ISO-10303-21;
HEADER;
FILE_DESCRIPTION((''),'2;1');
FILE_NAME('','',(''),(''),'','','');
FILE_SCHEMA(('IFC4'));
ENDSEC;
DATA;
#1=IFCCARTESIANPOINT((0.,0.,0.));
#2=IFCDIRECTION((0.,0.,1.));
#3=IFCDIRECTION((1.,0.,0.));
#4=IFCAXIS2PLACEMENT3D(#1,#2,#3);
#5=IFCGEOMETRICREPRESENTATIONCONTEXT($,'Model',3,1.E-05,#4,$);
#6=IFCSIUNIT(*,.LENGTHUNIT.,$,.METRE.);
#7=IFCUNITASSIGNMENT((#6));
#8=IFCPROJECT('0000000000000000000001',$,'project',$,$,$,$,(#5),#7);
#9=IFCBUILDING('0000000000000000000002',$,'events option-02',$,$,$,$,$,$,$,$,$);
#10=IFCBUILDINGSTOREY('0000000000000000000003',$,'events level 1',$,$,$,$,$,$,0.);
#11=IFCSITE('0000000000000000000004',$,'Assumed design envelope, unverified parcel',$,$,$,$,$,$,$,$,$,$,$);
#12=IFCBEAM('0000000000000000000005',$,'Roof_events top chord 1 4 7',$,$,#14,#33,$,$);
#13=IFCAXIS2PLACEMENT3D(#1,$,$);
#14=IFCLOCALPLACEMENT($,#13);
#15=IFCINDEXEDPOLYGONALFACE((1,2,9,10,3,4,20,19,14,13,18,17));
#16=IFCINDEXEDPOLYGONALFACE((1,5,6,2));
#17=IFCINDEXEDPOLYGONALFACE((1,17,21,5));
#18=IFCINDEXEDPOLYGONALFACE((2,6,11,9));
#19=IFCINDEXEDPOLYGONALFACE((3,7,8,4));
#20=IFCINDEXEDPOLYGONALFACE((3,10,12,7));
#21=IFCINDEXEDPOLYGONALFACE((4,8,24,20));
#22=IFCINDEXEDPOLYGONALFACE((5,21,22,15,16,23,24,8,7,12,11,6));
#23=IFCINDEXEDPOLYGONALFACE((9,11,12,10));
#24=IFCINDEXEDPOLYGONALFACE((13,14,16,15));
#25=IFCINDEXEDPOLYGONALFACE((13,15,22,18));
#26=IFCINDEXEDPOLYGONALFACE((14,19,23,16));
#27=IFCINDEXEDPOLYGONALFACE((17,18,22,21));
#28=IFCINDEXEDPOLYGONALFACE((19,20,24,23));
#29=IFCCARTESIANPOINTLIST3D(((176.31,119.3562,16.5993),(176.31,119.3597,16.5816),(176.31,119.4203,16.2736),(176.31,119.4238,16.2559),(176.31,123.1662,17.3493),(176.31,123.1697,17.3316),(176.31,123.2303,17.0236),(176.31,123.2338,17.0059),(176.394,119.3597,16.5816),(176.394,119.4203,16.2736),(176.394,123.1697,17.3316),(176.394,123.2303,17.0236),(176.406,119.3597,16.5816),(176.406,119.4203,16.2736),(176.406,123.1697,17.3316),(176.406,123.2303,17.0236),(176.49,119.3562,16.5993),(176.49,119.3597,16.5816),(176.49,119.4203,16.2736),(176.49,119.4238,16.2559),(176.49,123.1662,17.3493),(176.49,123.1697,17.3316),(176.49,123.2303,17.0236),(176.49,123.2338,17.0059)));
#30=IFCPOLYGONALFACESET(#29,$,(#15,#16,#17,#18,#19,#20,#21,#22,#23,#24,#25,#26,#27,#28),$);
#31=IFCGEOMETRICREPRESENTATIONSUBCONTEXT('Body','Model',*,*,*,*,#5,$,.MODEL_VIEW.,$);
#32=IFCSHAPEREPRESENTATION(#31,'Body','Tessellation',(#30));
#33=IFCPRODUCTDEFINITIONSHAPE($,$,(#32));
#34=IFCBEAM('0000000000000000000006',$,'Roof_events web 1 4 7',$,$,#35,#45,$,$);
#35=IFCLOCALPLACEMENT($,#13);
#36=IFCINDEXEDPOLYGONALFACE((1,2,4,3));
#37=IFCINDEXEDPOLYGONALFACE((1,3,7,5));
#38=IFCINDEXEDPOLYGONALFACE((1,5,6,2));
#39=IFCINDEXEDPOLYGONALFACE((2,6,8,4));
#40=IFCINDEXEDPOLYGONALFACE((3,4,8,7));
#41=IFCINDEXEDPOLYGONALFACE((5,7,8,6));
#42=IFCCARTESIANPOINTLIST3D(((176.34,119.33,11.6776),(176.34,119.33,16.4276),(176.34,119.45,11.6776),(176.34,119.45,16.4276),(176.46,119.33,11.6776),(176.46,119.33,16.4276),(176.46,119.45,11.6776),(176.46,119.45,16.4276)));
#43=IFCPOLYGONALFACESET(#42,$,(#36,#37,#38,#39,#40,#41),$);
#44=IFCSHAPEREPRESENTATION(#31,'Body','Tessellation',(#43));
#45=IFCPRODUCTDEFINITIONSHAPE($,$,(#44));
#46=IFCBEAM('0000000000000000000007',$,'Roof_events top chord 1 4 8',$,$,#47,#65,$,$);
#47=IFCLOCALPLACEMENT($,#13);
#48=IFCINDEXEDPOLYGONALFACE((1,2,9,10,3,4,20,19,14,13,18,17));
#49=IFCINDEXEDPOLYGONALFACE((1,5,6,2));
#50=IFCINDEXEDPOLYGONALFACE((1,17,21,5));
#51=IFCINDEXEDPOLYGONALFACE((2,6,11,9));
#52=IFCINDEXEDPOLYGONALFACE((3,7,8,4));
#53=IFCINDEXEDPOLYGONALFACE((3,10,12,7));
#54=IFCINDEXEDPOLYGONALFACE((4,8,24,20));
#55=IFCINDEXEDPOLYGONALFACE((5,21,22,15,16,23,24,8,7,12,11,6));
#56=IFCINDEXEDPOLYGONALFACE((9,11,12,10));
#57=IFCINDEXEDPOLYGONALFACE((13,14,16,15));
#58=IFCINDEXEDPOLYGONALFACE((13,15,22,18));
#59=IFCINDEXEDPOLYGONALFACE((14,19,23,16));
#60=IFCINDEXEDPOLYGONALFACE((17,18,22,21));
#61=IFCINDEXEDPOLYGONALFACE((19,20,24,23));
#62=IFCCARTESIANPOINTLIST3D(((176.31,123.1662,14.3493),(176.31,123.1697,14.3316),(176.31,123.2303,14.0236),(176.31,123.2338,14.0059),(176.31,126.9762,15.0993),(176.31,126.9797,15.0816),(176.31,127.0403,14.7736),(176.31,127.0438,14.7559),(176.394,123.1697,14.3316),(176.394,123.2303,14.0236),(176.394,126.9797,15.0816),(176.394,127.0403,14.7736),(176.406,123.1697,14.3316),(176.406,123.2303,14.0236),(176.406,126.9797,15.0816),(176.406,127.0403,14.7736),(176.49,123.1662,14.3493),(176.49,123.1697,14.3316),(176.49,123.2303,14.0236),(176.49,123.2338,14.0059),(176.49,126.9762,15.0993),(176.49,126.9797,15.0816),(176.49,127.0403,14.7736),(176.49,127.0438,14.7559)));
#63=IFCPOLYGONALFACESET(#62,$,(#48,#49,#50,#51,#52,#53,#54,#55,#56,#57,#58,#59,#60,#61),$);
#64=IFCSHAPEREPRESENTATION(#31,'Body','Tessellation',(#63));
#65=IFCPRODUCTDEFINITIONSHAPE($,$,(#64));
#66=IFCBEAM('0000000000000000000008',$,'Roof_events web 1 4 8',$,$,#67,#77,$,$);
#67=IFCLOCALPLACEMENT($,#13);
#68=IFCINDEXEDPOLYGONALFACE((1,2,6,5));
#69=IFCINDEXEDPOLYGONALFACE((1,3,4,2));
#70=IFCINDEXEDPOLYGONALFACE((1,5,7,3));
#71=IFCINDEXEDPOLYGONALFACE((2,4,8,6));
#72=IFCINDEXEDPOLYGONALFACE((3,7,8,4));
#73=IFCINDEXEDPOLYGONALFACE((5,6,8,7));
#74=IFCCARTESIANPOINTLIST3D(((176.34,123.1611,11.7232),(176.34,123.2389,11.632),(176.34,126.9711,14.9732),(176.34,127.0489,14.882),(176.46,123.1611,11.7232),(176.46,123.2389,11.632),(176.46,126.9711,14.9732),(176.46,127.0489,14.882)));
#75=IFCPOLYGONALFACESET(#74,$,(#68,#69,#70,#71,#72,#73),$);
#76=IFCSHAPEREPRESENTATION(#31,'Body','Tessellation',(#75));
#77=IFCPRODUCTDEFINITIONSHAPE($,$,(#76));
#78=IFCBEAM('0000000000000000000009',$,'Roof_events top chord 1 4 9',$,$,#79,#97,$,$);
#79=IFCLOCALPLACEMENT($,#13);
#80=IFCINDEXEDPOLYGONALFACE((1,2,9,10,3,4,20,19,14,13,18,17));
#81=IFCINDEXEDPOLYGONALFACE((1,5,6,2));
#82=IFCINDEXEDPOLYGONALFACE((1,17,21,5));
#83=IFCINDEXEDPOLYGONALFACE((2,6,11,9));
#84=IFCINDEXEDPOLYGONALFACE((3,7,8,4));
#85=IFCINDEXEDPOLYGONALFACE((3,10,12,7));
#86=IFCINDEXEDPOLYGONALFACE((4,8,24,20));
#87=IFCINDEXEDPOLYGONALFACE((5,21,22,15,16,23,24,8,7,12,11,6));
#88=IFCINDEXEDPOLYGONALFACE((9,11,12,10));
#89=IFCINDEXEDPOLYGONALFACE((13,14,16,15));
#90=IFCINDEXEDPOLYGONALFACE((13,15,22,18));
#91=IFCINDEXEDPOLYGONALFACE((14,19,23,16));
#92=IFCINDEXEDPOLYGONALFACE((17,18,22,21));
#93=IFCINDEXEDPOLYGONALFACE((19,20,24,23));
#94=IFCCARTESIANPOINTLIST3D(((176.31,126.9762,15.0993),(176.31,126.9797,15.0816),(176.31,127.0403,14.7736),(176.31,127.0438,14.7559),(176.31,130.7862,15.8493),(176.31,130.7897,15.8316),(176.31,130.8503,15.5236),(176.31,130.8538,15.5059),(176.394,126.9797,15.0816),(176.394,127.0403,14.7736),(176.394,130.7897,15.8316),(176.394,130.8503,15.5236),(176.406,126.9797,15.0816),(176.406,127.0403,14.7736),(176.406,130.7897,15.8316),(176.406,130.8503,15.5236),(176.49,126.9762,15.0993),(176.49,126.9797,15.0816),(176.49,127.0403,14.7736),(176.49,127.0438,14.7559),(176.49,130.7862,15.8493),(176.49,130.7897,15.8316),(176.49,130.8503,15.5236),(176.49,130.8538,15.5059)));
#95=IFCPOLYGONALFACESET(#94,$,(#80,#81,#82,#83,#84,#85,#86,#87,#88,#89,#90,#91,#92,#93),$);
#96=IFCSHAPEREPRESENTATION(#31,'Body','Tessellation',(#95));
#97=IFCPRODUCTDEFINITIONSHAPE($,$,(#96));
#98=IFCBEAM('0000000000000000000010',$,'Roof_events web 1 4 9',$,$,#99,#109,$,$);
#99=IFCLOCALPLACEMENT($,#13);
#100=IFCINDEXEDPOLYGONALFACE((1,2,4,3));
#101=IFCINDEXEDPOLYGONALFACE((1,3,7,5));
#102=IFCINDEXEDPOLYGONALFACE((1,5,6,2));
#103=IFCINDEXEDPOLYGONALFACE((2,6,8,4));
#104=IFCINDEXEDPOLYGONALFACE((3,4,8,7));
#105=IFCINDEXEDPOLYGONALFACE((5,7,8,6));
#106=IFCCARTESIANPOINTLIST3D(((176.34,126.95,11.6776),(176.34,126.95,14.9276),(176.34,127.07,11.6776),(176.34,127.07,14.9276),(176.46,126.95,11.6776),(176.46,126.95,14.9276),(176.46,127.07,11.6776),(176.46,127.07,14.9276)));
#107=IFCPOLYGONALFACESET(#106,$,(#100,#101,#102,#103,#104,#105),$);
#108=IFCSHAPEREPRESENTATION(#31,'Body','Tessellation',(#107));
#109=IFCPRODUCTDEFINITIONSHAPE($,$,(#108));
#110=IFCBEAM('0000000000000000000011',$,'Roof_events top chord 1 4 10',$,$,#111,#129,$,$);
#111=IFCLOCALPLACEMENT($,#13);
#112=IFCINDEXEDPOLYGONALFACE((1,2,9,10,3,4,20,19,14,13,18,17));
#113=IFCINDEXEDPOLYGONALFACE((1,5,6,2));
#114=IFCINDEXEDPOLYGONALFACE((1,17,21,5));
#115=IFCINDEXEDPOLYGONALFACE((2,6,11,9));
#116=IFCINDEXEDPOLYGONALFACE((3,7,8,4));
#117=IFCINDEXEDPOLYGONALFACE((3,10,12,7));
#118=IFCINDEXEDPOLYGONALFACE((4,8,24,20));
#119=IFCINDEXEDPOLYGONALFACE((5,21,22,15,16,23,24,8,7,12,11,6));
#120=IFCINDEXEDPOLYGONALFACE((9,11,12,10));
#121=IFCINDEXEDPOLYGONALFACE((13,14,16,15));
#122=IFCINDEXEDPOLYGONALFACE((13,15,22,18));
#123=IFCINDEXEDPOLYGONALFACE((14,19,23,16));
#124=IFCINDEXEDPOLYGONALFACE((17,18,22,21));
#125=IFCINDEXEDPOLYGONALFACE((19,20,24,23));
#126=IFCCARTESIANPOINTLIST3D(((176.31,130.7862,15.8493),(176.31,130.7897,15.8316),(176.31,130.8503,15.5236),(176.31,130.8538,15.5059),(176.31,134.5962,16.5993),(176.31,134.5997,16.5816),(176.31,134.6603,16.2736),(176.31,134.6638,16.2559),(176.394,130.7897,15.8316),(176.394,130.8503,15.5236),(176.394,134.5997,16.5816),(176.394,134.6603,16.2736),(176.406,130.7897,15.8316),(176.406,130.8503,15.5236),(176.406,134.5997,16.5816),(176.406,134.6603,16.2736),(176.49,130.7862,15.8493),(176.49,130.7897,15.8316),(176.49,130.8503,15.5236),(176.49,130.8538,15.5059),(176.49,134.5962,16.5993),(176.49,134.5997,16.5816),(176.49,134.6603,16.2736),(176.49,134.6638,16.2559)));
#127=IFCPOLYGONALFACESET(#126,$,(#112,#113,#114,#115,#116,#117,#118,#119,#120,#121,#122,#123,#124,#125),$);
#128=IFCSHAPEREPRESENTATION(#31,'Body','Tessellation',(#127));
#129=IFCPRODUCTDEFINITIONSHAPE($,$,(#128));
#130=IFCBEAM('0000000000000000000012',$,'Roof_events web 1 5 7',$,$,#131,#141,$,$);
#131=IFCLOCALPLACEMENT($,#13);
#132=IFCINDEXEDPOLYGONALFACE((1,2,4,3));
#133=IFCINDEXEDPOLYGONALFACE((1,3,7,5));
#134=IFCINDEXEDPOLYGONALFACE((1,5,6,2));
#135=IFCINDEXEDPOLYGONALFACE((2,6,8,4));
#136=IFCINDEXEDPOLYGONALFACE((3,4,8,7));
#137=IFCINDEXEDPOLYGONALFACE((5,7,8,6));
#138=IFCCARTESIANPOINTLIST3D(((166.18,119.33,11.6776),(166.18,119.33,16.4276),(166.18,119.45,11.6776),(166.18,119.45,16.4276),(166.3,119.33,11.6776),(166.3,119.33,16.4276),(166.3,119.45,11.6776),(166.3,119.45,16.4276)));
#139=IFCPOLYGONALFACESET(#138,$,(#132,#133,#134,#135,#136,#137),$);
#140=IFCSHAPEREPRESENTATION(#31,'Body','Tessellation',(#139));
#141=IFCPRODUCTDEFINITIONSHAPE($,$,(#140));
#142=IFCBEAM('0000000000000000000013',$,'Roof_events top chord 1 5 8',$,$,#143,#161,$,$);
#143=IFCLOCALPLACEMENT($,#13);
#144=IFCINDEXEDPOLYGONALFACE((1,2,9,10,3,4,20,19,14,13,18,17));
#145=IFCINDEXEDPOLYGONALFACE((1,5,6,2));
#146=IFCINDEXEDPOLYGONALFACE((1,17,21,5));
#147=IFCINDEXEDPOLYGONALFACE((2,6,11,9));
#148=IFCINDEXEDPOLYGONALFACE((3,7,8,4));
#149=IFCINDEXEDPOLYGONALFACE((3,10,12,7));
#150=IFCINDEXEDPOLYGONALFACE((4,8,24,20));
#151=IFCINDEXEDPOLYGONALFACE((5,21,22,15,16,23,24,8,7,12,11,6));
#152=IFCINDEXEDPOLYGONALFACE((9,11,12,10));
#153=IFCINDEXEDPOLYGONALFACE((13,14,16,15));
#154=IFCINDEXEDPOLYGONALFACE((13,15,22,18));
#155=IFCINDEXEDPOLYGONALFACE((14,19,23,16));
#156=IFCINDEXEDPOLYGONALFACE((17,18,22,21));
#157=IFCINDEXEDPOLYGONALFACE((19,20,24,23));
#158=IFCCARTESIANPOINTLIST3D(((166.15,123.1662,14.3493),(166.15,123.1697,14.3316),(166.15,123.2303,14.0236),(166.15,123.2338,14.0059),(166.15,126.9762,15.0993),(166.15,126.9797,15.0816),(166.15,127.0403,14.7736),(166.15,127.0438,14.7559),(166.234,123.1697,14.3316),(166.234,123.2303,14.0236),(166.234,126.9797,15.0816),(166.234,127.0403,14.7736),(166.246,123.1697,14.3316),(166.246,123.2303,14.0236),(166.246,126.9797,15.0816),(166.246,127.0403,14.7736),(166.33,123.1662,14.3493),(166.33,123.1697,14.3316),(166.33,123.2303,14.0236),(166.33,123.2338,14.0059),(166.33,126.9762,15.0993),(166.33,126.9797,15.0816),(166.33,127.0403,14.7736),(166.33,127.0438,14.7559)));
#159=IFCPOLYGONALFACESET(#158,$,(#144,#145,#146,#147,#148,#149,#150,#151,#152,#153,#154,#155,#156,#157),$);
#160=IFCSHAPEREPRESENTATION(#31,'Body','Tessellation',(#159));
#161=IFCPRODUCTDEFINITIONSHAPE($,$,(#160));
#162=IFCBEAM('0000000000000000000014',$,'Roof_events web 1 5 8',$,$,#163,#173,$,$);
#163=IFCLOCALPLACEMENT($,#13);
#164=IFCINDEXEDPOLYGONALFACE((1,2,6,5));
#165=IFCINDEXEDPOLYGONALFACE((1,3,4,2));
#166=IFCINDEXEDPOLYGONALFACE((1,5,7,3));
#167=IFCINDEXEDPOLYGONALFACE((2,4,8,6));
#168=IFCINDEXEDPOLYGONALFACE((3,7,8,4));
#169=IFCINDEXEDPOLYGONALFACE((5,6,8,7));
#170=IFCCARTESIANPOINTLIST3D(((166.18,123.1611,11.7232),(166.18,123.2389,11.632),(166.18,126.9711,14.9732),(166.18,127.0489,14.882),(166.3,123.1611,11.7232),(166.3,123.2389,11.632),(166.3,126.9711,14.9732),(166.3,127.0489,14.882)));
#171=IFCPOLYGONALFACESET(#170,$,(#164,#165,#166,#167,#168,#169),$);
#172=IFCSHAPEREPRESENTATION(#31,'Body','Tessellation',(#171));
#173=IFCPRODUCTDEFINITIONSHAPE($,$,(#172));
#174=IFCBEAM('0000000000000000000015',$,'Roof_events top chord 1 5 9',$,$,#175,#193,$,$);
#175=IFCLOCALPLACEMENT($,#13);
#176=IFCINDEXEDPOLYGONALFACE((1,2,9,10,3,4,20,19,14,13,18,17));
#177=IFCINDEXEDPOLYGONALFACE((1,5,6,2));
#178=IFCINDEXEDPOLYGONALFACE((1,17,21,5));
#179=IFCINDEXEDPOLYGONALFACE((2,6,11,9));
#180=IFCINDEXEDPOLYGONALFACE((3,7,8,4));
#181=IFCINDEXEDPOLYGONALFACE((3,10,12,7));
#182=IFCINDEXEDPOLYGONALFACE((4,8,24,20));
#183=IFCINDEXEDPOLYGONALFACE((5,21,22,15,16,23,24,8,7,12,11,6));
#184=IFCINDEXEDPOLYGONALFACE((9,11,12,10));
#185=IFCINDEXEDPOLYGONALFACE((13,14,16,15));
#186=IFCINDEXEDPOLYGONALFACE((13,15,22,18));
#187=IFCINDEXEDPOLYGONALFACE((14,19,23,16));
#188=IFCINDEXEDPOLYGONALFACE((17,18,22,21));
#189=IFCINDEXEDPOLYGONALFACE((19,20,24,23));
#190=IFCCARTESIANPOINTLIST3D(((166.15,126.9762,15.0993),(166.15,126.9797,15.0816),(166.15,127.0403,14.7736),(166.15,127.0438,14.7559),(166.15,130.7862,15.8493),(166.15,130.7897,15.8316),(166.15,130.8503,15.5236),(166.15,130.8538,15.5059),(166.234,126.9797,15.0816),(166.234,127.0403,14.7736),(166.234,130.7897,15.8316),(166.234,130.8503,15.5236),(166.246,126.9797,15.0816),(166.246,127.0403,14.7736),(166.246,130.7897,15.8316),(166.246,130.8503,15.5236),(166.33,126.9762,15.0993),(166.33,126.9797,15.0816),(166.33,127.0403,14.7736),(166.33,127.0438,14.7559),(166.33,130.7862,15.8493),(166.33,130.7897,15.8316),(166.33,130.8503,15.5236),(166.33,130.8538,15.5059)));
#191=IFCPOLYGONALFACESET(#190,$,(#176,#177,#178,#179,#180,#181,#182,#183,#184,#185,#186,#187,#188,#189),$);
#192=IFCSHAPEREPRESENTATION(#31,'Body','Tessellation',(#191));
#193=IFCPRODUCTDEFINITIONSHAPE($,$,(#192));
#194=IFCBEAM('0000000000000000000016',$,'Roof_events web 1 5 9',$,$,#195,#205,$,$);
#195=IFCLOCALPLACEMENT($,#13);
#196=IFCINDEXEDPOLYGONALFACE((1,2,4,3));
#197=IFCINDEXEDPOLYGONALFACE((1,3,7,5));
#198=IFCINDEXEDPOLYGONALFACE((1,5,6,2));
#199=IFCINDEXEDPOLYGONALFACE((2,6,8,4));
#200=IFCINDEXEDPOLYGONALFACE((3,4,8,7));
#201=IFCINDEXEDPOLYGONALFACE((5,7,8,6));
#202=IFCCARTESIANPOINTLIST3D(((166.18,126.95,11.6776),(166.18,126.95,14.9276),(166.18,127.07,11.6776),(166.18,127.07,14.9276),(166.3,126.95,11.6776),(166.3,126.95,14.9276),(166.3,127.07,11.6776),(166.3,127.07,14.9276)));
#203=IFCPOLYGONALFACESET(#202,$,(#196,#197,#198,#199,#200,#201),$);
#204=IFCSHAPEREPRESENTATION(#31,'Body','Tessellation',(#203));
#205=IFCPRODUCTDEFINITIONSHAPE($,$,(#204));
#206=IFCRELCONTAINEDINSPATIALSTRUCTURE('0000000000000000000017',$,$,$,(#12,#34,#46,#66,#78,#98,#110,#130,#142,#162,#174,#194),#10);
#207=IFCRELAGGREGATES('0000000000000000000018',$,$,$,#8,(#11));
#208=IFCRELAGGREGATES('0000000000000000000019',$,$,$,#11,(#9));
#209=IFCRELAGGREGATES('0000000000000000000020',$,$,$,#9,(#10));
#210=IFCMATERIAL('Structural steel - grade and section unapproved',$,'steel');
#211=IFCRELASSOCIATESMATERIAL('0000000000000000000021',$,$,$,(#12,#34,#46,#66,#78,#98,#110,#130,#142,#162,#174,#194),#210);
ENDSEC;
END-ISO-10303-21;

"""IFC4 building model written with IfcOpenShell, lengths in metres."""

from ifc_helpers import new_model, si_unit, frame, origin_with_axes, place, context, subcontext, project, spatial, rectangle, i_section, extrude, material, element, save


model = new_model("IFC4")

# Units and contexts
model_context = context("Model", 3, precision=1e-05, world=origin_with_axes())
body_context = subcontext(model_context, "Body", "Model", "MODEL_VIEW")
ifc_project = project(units=[si_unit("LENGTHUNIT", "METRE")], contexts=[model_context])

# Site, building, storey
site = spatial("IfcSite", under=ifc_project, Name="Assumed design envelope, unverified parcel")
building = spatial("IfcBuilding", under=site, Name="events option-02")
storey = spatial("IfcBuildingStorey", under=building, Name="events level 1", Elevation=0.0)

# Beams
ifc_material_1 = material(Name="Structural steel - grade and section unapproved", Category="steel")
beam_1_placement = place(None, frame((176.4, 119.39, 16.4276), z_axis=(0.0, 0.98117, 0.193144), x_axis=(-1.0, 0.0, 0.0)))
element("IfcBeam", 1, at=beam_1_placement, inside=storey, material=ifc_material_1, Name="Roof_events top chord 1 4 7", context=body_context, shape_type="SweptSolid", body=[
    extrude(i_section(OverallWidth=0.18, OverallDepth=0.35, WebThickness=0.012, FlangeThickness=0.018, FilletRadius=0.0), origin_with_axes(), (0.0, 0.0, 1.0), 3.8831),
])
beam_2_placement = place(None, frame((176.4, 119.39, 11.6776), z_axis=(0.0, 0.0, 1.0), x_axis=(-1.0, 0.0, 0.0)))
element("IfcBeam", 2, at=beam_2_placement, inside=storey, material=ifc_material_1, Name="Roof_events web 1 4 7", context=body_context, shape_type="SweptSolid", body=[
    extrude(rectangle(XDim=0.12, YDim=0.12), origin_with_axes(), (0.0, 0.0, 1.0), 4.75),
])
beam_3_placement = place(None, frame((176.4, 123.2, 14.1776), z_axis=(0.0, 0.98117, 0.193144), x_axis=(-1.0, 0.0, 0.0)))
element("IfcBeam", 3, at=beam_3_placement, inside=storey, material=ifc_material_1, Name="Roof_events top chord 1 4 8", context=body_context, shape_type="SweptSolid", body=[
    extrude(i_section(OverallWidth=0.18, OverallDepth=0.35, WebThickness=0.012, FlangeThickness=0.018, FilletRadius=0.0), origin_with_axes(), (0.0, 0.0, 1.0), 3.8831),
])
beam_4_placement = place(None, frame((176.4, 123.2, 11.6776), z_axis=(0.0, 0.760805, 0.64898), x_axis=(-1.0, 0.0, 0.0)))
element("IfcBeam", 4, at=beam_4_placement, inside=storey, material=ifc_material_1, Name="Roof_events web 1 4 8", context=body_context, shape_type="SweptSolid", body=[
    extrude(rectangle(XDim=0.12, YDim=0.12), origin_with_axes(), (0.0, 0.0, 1.0), 5.0079),
])
beam_5_placement = place(None, frame((176.4, 127.01, 14.9276), z_axis=(0.0, 0.98117, 0.193144), x_axis=(-1.0, 0.0, 0.0)))
element("IfcBeam", 5, at=beam_5_placement, inside=storey, material=ifc_material_1, Name="Roof_events top chord 1 4 9", context=body_context, shape_type="SweptSolid", body=[
    extrude(i_section(OverallWidth=0.18, OverallDepth=0.35, WebThickness=0.012, FlangeThickness=0.018, FilletRadius=0.0), origin_with_axes(), (0.0, 0.0, 1.0), 3.8831),
])
beam_6_placement = place(None, frame((176.4, 127.01, 11.6776), z_axis=(0.0, 0.0, 1.0), x_axis=(-1.0, 0.0, 0.0)))
element("IfcBeam", 6, at=beam_6_placement, inside=storey, material=ifc_material_1, Name="Roof_events web 1 4 9", context=body_context, shape_type="SweptSolid", body=[
    extrude(rectangle(XDim=0.12, YDim=0.12), origin_with_axes(), (0.0, 0.0, 1.0), 3.25),
])
beam_7_placement = place(None, frame((176.4, 130.82, 15.6776), z_axis=(0.0, 0.98117, 0.193144), x_axis=(-1.0, 0.0, 0.0)))
element("IfcBeam", 7, at=beam_7_placement, inside=storey, material=ifc_material_1, Name="Roof_events top chord 1 4 10", context=body_context, shape_type="SweptSolid", body=[
    extrude(i_section(OverallWidth=0.18, OverallDepth=0.35, WebThickness=0.012, FlangeThickness=0.018, FilletRadius=0.0), origin_with_axes(), (0.0, 0.0, 1.0), 3.8831),
])
beam_8_placement = place(None, frame((166.24, 119.39, 11.6776), z_axis=(0.0, 0.0, 1.0), x_axis=(-1.0, 0.0, 0.0)))
element("IfcBeam", 8, at=beam_8_placement, inside=storey, material=ifc_material_1, Name="Roof_events web 1 5 7", context=body_context, shape_type="SweptSolid", body=[
    extrude(rectangle(XDim=0.12, YDim=0.12), origin_with_axes(), (0.0, 0.0, 1.0), 4.75),
])
beam_9_placement = place(None, frame((166.24, 123.2, 14.1776), z_axis=(0.0, 0.98117, 0.193144), x_axis=(-1.0, 0.0, 0.0)))
element("IfcBeam", 9, at=beam_9_placement, inside=storey, material=ifc_material_1, Name="Roof_events top chord 1 5 8", context=body_context, shape_type="SweptSolid", body=[
    extrude(i_section(OverallWidth=0.18, OverallDepth=0.35, WebThickness=0.012, FlangeThickness=0.018, FilletRadius=0.0), origin_with_axes(), (0.0, 0.0, 1.0), 3.8831),
])
beam_10_placement = place(None, frame((166.24, 123.2, 11.6776), z_axis=(0.0, 0.760805, 0.64898), x_axis=(-1.0, 0.0, 0.0)))
element("IfcBeam", 10, at=beam_10_placement, inside=storey, material=ifc_material_1, Name="Roof_events web 1 5 8", context=body_context, shape_type="SweptSolid", body=[
    extrude(rectangle(XDim=0.12, YDim=0.12), origin_with_axes(), (0.0, 0.0, 1.0), 5.0079),
])
beam_11_placement = place(None, frame((166.24, 127.01, 14.9276), z_axis=(0.0, 0.98117, 0.193144), x_axis=(-1.0, 0.0, 0.0)))
element("IfcBeam", 11, at=beam_11_placement, inside=storey, material=ifc_material_1, Name="Roof_events top chord 1 5 9", context=body_context, shape_type="SweptSolid", body=[
    extrude(i_section(OverallWidth=0.18, OverallDepth=0.35, WebThickness=0.012, FlangeThickness=0.018, FilletRadius=0.0), origin_with_axes(), (0.0, 0.0, 1.0), 3.8831),
])
beam_12_placement = place(None, frame((166.24, 127.01, 11.6776), z_axis=(0.0, 0.0, 1.0), x_axis=(-1.0, 0.0, 0.0)))
element("IfcBeam", 12, at=beam_12_placement, inside=storey, material=ifc_material_1, Name="Roof_events web 1 5 9", context=body_context, shape_type="SweptSolid", body=[
    extrude(rectangle(XDim=0.12, YDim=0.12), origin_with_axes(), (0.0, 0.0, 1.0), 3.25),
])

save(model, "model.ifc")
